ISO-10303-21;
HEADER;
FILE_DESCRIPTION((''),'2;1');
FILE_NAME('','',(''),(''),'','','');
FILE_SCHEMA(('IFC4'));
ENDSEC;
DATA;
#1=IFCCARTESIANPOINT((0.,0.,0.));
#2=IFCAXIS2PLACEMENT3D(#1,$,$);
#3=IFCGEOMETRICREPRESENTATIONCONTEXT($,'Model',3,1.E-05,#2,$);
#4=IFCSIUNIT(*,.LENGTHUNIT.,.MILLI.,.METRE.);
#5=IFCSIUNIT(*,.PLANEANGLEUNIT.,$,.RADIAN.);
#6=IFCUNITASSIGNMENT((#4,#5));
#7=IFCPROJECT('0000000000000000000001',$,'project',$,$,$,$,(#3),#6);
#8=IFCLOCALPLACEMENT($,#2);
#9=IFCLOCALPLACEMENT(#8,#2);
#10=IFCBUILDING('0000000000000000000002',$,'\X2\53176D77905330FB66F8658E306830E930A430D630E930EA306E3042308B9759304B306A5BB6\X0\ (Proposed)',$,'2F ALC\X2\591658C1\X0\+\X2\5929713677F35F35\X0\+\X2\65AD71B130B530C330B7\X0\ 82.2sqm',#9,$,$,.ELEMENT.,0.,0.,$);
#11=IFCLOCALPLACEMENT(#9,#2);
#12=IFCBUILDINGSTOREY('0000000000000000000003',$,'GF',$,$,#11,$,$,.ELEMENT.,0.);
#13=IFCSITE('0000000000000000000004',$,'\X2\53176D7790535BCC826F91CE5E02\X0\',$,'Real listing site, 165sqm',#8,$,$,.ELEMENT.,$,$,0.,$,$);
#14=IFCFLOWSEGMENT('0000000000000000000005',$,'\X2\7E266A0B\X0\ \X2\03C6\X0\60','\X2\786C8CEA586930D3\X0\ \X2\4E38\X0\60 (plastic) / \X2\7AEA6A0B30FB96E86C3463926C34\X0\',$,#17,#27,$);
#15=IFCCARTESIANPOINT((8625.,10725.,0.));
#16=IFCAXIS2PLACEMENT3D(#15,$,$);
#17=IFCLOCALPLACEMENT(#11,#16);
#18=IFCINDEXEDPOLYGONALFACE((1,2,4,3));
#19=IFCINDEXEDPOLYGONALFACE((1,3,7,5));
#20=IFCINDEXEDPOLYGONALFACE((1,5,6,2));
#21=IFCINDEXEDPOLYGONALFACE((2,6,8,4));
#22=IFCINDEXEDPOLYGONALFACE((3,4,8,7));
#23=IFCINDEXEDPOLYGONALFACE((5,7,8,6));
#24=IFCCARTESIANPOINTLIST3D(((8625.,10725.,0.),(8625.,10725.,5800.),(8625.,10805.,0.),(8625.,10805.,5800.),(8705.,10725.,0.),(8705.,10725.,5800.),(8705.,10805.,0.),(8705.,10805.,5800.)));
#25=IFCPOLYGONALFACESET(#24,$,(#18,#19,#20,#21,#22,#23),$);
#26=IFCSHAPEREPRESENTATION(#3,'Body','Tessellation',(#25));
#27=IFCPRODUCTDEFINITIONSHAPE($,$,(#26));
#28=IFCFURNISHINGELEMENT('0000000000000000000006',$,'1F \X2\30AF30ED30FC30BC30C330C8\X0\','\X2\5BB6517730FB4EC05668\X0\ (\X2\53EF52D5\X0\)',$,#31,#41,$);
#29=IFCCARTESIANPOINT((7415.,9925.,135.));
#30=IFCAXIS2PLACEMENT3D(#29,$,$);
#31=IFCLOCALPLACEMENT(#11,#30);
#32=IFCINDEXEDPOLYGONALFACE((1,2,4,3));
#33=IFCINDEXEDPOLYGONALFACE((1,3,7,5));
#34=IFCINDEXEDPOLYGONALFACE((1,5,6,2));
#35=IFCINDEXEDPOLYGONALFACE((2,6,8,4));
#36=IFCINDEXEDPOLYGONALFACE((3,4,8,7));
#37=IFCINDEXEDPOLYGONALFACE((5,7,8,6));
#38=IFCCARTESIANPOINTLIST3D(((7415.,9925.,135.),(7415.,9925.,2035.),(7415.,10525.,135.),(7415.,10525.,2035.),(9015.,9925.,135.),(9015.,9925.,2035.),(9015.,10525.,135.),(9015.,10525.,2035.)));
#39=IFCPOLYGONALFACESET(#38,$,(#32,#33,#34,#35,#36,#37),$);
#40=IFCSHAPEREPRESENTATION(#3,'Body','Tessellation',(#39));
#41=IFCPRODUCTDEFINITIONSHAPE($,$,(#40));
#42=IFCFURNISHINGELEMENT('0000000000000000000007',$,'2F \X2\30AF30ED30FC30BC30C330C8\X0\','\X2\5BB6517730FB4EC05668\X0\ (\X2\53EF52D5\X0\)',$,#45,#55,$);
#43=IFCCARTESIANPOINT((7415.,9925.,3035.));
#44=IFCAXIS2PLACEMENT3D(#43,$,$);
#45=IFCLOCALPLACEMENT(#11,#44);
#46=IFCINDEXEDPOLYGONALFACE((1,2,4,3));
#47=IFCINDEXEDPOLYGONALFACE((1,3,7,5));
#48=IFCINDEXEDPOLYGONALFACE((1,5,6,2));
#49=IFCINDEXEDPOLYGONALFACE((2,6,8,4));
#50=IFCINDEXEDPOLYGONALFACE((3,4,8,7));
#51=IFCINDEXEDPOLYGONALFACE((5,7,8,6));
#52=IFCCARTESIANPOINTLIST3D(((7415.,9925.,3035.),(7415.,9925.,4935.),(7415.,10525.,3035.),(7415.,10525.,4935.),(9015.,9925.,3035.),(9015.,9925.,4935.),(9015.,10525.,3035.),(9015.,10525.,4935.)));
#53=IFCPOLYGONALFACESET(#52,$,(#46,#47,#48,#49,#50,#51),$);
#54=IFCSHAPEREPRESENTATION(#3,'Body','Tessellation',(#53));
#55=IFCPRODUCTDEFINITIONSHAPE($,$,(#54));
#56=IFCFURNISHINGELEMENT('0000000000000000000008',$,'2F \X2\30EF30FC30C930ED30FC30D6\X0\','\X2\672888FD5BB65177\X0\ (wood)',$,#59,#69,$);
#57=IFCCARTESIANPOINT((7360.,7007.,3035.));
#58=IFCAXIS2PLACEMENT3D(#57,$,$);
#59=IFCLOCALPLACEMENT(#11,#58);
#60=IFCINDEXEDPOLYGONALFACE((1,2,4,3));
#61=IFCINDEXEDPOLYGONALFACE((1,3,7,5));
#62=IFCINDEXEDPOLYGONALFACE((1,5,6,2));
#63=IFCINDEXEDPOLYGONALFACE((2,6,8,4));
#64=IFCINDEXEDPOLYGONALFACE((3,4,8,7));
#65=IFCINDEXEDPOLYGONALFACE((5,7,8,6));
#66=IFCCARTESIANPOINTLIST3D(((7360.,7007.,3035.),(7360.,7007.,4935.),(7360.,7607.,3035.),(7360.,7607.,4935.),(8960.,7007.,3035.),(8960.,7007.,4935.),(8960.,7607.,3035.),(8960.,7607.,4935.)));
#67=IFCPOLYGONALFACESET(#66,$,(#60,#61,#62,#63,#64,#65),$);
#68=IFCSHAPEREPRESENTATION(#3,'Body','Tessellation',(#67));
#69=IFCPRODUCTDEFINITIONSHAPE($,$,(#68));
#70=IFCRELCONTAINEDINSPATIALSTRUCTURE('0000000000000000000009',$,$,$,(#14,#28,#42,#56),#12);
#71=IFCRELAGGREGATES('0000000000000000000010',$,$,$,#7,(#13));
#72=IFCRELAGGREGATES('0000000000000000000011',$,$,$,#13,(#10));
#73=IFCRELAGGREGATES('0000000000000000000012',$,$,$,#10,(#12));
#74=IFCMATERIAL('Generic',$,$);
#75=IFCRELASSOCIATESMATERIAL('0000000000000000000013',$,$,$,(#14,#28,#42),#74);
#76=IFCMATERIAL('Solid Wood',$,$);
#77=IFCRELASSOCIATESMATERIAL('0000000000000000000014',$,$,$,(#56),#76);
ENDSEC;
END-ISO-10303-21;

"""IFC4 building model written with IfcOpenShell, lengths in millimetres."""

from ifc_helpers import new_model, si_unit, frame, frame_2d, origin, place, context, project, spatial, rectangle, extrude, material, element, save


model = new_model("IFC4")

# Units and contexts
model_context = context("Model", 3, precision=1e-05, world=origin())
ifc_project = project(units=[si_unit("LENGTHUNIT", "METRE", prefix="MILLI"), si_unit("PLANEANGLEUNIT", "RADIAN")], contexts=[model_context])

# Site, building, storey
site_placement = place(None, origin())
site = spatial("IfcSite", under=ifc_project, at=site_placement, Name="北海道富良野市", ObjectType="Real listing site, 165sqm", CompositionType="ELEMENT", RefElevation=0.0)
building_placement = place(site_placement, origin())
building = spatial("IfcBuilding", under=site, at=building_placement, Name="北海道・書斎とライブラリのある静かな家 (Proposed)", ObjectType="2F ALC外壁+天然石張+断熱サッシ 82.2sqm", CompositionType="ELEMENT", ElevationOfRefHeight=0.0, ElevationOfTerrain=0.0)
storey_placement = place(building_placement, origin())
storey = spatial("IfcBuildingStorey", under=building, at=storey_placement, Name="GF", CompositionType="ELEMENT", Elevation=0.0)

# Shared definitions
ifc_material_1 = material(Name="Solid Wood")

# Shared definitions
ifc_material_2 = material(Name="Generic")

# Flow segment
flow_segment_placement = place(storey_placement, frame((8625.0, 10725.0, 0.0)))
element("IfcFlowSegment", 1, at=flow_segment_placement, inside=storey, material=ifc_material_2, Name="縦樋 φ60", Description="硬質塩ビ 丸60 (plastic) / 竪樋・雨水排水", context=model_context, shape_type="SweptSolid", body=[
    extrude(rectangle(XDim=80.0, YDim=80.0, at=frame_2d((40.0, 40.0))), frame((8625.0, 10725.0, 0.0)), (0.0, 0.0, 1.0), 5800.0),
])

# Furnishing elements
furnishing_1_placement = place(storey_placement, frame((7415.0, 9925.0, 135.0)))
element("IfcFurnishingElement", 2, at=furnishing_1_placement, inside=storey, material=ifc_material_2, Name="1F クローゼット", Description="家具・什器 (可動)", context=model_context, shape_type="SweptSolid", body=[
    extrude(rectangle(XDim=1600.0, YDim=600.0, at=frame_2d((800.0, 300.0))), frame((7415.0, 9925.0, 135.0)), (0.0, 0.0, 1.0), 1900.0),
])
furnishing_2_placement = place(storey_placement, frame((7415.0, 9925.0, 3035.0)))
element("IfcFurnishingElement", 3, at=furnishing_2_placement, inside=storey, material=ifc_material_2, Name="2F クローゼット", Description="家具・什器 (可動)", context=model_context, shape_type="SweptSolid", body=[
    extrude(rectangle(XDim=1600.0, YDim=600.0, at=frame_2d((800.0, 300.0))), frame((7415.0, 9925.0, 3035.0)), (0.0, 0.0, 1.0), 1900.0),
])
furnishing_3_placement = place(storey_placement, frame((7360.0, 7007.0, 3035.0)))
element("IfcFurnishingElement", 4, at=furnishing_3_placement, inside=storey, material=ifc_material_1, Name="2F ワードローブ", Description="木製家具 (wood)", context=model_context, shape_type="SweptSolid", body=[
    extrude(rectangle(XDim=1600.0, YDim=600.0, at=frame_2d((800.0, 300.0))), frame((7360.0, 7007.0, 3035.0)), (0.0, 0.0, 1.0), 1900.0),
])

save(model, "model.ifc")
